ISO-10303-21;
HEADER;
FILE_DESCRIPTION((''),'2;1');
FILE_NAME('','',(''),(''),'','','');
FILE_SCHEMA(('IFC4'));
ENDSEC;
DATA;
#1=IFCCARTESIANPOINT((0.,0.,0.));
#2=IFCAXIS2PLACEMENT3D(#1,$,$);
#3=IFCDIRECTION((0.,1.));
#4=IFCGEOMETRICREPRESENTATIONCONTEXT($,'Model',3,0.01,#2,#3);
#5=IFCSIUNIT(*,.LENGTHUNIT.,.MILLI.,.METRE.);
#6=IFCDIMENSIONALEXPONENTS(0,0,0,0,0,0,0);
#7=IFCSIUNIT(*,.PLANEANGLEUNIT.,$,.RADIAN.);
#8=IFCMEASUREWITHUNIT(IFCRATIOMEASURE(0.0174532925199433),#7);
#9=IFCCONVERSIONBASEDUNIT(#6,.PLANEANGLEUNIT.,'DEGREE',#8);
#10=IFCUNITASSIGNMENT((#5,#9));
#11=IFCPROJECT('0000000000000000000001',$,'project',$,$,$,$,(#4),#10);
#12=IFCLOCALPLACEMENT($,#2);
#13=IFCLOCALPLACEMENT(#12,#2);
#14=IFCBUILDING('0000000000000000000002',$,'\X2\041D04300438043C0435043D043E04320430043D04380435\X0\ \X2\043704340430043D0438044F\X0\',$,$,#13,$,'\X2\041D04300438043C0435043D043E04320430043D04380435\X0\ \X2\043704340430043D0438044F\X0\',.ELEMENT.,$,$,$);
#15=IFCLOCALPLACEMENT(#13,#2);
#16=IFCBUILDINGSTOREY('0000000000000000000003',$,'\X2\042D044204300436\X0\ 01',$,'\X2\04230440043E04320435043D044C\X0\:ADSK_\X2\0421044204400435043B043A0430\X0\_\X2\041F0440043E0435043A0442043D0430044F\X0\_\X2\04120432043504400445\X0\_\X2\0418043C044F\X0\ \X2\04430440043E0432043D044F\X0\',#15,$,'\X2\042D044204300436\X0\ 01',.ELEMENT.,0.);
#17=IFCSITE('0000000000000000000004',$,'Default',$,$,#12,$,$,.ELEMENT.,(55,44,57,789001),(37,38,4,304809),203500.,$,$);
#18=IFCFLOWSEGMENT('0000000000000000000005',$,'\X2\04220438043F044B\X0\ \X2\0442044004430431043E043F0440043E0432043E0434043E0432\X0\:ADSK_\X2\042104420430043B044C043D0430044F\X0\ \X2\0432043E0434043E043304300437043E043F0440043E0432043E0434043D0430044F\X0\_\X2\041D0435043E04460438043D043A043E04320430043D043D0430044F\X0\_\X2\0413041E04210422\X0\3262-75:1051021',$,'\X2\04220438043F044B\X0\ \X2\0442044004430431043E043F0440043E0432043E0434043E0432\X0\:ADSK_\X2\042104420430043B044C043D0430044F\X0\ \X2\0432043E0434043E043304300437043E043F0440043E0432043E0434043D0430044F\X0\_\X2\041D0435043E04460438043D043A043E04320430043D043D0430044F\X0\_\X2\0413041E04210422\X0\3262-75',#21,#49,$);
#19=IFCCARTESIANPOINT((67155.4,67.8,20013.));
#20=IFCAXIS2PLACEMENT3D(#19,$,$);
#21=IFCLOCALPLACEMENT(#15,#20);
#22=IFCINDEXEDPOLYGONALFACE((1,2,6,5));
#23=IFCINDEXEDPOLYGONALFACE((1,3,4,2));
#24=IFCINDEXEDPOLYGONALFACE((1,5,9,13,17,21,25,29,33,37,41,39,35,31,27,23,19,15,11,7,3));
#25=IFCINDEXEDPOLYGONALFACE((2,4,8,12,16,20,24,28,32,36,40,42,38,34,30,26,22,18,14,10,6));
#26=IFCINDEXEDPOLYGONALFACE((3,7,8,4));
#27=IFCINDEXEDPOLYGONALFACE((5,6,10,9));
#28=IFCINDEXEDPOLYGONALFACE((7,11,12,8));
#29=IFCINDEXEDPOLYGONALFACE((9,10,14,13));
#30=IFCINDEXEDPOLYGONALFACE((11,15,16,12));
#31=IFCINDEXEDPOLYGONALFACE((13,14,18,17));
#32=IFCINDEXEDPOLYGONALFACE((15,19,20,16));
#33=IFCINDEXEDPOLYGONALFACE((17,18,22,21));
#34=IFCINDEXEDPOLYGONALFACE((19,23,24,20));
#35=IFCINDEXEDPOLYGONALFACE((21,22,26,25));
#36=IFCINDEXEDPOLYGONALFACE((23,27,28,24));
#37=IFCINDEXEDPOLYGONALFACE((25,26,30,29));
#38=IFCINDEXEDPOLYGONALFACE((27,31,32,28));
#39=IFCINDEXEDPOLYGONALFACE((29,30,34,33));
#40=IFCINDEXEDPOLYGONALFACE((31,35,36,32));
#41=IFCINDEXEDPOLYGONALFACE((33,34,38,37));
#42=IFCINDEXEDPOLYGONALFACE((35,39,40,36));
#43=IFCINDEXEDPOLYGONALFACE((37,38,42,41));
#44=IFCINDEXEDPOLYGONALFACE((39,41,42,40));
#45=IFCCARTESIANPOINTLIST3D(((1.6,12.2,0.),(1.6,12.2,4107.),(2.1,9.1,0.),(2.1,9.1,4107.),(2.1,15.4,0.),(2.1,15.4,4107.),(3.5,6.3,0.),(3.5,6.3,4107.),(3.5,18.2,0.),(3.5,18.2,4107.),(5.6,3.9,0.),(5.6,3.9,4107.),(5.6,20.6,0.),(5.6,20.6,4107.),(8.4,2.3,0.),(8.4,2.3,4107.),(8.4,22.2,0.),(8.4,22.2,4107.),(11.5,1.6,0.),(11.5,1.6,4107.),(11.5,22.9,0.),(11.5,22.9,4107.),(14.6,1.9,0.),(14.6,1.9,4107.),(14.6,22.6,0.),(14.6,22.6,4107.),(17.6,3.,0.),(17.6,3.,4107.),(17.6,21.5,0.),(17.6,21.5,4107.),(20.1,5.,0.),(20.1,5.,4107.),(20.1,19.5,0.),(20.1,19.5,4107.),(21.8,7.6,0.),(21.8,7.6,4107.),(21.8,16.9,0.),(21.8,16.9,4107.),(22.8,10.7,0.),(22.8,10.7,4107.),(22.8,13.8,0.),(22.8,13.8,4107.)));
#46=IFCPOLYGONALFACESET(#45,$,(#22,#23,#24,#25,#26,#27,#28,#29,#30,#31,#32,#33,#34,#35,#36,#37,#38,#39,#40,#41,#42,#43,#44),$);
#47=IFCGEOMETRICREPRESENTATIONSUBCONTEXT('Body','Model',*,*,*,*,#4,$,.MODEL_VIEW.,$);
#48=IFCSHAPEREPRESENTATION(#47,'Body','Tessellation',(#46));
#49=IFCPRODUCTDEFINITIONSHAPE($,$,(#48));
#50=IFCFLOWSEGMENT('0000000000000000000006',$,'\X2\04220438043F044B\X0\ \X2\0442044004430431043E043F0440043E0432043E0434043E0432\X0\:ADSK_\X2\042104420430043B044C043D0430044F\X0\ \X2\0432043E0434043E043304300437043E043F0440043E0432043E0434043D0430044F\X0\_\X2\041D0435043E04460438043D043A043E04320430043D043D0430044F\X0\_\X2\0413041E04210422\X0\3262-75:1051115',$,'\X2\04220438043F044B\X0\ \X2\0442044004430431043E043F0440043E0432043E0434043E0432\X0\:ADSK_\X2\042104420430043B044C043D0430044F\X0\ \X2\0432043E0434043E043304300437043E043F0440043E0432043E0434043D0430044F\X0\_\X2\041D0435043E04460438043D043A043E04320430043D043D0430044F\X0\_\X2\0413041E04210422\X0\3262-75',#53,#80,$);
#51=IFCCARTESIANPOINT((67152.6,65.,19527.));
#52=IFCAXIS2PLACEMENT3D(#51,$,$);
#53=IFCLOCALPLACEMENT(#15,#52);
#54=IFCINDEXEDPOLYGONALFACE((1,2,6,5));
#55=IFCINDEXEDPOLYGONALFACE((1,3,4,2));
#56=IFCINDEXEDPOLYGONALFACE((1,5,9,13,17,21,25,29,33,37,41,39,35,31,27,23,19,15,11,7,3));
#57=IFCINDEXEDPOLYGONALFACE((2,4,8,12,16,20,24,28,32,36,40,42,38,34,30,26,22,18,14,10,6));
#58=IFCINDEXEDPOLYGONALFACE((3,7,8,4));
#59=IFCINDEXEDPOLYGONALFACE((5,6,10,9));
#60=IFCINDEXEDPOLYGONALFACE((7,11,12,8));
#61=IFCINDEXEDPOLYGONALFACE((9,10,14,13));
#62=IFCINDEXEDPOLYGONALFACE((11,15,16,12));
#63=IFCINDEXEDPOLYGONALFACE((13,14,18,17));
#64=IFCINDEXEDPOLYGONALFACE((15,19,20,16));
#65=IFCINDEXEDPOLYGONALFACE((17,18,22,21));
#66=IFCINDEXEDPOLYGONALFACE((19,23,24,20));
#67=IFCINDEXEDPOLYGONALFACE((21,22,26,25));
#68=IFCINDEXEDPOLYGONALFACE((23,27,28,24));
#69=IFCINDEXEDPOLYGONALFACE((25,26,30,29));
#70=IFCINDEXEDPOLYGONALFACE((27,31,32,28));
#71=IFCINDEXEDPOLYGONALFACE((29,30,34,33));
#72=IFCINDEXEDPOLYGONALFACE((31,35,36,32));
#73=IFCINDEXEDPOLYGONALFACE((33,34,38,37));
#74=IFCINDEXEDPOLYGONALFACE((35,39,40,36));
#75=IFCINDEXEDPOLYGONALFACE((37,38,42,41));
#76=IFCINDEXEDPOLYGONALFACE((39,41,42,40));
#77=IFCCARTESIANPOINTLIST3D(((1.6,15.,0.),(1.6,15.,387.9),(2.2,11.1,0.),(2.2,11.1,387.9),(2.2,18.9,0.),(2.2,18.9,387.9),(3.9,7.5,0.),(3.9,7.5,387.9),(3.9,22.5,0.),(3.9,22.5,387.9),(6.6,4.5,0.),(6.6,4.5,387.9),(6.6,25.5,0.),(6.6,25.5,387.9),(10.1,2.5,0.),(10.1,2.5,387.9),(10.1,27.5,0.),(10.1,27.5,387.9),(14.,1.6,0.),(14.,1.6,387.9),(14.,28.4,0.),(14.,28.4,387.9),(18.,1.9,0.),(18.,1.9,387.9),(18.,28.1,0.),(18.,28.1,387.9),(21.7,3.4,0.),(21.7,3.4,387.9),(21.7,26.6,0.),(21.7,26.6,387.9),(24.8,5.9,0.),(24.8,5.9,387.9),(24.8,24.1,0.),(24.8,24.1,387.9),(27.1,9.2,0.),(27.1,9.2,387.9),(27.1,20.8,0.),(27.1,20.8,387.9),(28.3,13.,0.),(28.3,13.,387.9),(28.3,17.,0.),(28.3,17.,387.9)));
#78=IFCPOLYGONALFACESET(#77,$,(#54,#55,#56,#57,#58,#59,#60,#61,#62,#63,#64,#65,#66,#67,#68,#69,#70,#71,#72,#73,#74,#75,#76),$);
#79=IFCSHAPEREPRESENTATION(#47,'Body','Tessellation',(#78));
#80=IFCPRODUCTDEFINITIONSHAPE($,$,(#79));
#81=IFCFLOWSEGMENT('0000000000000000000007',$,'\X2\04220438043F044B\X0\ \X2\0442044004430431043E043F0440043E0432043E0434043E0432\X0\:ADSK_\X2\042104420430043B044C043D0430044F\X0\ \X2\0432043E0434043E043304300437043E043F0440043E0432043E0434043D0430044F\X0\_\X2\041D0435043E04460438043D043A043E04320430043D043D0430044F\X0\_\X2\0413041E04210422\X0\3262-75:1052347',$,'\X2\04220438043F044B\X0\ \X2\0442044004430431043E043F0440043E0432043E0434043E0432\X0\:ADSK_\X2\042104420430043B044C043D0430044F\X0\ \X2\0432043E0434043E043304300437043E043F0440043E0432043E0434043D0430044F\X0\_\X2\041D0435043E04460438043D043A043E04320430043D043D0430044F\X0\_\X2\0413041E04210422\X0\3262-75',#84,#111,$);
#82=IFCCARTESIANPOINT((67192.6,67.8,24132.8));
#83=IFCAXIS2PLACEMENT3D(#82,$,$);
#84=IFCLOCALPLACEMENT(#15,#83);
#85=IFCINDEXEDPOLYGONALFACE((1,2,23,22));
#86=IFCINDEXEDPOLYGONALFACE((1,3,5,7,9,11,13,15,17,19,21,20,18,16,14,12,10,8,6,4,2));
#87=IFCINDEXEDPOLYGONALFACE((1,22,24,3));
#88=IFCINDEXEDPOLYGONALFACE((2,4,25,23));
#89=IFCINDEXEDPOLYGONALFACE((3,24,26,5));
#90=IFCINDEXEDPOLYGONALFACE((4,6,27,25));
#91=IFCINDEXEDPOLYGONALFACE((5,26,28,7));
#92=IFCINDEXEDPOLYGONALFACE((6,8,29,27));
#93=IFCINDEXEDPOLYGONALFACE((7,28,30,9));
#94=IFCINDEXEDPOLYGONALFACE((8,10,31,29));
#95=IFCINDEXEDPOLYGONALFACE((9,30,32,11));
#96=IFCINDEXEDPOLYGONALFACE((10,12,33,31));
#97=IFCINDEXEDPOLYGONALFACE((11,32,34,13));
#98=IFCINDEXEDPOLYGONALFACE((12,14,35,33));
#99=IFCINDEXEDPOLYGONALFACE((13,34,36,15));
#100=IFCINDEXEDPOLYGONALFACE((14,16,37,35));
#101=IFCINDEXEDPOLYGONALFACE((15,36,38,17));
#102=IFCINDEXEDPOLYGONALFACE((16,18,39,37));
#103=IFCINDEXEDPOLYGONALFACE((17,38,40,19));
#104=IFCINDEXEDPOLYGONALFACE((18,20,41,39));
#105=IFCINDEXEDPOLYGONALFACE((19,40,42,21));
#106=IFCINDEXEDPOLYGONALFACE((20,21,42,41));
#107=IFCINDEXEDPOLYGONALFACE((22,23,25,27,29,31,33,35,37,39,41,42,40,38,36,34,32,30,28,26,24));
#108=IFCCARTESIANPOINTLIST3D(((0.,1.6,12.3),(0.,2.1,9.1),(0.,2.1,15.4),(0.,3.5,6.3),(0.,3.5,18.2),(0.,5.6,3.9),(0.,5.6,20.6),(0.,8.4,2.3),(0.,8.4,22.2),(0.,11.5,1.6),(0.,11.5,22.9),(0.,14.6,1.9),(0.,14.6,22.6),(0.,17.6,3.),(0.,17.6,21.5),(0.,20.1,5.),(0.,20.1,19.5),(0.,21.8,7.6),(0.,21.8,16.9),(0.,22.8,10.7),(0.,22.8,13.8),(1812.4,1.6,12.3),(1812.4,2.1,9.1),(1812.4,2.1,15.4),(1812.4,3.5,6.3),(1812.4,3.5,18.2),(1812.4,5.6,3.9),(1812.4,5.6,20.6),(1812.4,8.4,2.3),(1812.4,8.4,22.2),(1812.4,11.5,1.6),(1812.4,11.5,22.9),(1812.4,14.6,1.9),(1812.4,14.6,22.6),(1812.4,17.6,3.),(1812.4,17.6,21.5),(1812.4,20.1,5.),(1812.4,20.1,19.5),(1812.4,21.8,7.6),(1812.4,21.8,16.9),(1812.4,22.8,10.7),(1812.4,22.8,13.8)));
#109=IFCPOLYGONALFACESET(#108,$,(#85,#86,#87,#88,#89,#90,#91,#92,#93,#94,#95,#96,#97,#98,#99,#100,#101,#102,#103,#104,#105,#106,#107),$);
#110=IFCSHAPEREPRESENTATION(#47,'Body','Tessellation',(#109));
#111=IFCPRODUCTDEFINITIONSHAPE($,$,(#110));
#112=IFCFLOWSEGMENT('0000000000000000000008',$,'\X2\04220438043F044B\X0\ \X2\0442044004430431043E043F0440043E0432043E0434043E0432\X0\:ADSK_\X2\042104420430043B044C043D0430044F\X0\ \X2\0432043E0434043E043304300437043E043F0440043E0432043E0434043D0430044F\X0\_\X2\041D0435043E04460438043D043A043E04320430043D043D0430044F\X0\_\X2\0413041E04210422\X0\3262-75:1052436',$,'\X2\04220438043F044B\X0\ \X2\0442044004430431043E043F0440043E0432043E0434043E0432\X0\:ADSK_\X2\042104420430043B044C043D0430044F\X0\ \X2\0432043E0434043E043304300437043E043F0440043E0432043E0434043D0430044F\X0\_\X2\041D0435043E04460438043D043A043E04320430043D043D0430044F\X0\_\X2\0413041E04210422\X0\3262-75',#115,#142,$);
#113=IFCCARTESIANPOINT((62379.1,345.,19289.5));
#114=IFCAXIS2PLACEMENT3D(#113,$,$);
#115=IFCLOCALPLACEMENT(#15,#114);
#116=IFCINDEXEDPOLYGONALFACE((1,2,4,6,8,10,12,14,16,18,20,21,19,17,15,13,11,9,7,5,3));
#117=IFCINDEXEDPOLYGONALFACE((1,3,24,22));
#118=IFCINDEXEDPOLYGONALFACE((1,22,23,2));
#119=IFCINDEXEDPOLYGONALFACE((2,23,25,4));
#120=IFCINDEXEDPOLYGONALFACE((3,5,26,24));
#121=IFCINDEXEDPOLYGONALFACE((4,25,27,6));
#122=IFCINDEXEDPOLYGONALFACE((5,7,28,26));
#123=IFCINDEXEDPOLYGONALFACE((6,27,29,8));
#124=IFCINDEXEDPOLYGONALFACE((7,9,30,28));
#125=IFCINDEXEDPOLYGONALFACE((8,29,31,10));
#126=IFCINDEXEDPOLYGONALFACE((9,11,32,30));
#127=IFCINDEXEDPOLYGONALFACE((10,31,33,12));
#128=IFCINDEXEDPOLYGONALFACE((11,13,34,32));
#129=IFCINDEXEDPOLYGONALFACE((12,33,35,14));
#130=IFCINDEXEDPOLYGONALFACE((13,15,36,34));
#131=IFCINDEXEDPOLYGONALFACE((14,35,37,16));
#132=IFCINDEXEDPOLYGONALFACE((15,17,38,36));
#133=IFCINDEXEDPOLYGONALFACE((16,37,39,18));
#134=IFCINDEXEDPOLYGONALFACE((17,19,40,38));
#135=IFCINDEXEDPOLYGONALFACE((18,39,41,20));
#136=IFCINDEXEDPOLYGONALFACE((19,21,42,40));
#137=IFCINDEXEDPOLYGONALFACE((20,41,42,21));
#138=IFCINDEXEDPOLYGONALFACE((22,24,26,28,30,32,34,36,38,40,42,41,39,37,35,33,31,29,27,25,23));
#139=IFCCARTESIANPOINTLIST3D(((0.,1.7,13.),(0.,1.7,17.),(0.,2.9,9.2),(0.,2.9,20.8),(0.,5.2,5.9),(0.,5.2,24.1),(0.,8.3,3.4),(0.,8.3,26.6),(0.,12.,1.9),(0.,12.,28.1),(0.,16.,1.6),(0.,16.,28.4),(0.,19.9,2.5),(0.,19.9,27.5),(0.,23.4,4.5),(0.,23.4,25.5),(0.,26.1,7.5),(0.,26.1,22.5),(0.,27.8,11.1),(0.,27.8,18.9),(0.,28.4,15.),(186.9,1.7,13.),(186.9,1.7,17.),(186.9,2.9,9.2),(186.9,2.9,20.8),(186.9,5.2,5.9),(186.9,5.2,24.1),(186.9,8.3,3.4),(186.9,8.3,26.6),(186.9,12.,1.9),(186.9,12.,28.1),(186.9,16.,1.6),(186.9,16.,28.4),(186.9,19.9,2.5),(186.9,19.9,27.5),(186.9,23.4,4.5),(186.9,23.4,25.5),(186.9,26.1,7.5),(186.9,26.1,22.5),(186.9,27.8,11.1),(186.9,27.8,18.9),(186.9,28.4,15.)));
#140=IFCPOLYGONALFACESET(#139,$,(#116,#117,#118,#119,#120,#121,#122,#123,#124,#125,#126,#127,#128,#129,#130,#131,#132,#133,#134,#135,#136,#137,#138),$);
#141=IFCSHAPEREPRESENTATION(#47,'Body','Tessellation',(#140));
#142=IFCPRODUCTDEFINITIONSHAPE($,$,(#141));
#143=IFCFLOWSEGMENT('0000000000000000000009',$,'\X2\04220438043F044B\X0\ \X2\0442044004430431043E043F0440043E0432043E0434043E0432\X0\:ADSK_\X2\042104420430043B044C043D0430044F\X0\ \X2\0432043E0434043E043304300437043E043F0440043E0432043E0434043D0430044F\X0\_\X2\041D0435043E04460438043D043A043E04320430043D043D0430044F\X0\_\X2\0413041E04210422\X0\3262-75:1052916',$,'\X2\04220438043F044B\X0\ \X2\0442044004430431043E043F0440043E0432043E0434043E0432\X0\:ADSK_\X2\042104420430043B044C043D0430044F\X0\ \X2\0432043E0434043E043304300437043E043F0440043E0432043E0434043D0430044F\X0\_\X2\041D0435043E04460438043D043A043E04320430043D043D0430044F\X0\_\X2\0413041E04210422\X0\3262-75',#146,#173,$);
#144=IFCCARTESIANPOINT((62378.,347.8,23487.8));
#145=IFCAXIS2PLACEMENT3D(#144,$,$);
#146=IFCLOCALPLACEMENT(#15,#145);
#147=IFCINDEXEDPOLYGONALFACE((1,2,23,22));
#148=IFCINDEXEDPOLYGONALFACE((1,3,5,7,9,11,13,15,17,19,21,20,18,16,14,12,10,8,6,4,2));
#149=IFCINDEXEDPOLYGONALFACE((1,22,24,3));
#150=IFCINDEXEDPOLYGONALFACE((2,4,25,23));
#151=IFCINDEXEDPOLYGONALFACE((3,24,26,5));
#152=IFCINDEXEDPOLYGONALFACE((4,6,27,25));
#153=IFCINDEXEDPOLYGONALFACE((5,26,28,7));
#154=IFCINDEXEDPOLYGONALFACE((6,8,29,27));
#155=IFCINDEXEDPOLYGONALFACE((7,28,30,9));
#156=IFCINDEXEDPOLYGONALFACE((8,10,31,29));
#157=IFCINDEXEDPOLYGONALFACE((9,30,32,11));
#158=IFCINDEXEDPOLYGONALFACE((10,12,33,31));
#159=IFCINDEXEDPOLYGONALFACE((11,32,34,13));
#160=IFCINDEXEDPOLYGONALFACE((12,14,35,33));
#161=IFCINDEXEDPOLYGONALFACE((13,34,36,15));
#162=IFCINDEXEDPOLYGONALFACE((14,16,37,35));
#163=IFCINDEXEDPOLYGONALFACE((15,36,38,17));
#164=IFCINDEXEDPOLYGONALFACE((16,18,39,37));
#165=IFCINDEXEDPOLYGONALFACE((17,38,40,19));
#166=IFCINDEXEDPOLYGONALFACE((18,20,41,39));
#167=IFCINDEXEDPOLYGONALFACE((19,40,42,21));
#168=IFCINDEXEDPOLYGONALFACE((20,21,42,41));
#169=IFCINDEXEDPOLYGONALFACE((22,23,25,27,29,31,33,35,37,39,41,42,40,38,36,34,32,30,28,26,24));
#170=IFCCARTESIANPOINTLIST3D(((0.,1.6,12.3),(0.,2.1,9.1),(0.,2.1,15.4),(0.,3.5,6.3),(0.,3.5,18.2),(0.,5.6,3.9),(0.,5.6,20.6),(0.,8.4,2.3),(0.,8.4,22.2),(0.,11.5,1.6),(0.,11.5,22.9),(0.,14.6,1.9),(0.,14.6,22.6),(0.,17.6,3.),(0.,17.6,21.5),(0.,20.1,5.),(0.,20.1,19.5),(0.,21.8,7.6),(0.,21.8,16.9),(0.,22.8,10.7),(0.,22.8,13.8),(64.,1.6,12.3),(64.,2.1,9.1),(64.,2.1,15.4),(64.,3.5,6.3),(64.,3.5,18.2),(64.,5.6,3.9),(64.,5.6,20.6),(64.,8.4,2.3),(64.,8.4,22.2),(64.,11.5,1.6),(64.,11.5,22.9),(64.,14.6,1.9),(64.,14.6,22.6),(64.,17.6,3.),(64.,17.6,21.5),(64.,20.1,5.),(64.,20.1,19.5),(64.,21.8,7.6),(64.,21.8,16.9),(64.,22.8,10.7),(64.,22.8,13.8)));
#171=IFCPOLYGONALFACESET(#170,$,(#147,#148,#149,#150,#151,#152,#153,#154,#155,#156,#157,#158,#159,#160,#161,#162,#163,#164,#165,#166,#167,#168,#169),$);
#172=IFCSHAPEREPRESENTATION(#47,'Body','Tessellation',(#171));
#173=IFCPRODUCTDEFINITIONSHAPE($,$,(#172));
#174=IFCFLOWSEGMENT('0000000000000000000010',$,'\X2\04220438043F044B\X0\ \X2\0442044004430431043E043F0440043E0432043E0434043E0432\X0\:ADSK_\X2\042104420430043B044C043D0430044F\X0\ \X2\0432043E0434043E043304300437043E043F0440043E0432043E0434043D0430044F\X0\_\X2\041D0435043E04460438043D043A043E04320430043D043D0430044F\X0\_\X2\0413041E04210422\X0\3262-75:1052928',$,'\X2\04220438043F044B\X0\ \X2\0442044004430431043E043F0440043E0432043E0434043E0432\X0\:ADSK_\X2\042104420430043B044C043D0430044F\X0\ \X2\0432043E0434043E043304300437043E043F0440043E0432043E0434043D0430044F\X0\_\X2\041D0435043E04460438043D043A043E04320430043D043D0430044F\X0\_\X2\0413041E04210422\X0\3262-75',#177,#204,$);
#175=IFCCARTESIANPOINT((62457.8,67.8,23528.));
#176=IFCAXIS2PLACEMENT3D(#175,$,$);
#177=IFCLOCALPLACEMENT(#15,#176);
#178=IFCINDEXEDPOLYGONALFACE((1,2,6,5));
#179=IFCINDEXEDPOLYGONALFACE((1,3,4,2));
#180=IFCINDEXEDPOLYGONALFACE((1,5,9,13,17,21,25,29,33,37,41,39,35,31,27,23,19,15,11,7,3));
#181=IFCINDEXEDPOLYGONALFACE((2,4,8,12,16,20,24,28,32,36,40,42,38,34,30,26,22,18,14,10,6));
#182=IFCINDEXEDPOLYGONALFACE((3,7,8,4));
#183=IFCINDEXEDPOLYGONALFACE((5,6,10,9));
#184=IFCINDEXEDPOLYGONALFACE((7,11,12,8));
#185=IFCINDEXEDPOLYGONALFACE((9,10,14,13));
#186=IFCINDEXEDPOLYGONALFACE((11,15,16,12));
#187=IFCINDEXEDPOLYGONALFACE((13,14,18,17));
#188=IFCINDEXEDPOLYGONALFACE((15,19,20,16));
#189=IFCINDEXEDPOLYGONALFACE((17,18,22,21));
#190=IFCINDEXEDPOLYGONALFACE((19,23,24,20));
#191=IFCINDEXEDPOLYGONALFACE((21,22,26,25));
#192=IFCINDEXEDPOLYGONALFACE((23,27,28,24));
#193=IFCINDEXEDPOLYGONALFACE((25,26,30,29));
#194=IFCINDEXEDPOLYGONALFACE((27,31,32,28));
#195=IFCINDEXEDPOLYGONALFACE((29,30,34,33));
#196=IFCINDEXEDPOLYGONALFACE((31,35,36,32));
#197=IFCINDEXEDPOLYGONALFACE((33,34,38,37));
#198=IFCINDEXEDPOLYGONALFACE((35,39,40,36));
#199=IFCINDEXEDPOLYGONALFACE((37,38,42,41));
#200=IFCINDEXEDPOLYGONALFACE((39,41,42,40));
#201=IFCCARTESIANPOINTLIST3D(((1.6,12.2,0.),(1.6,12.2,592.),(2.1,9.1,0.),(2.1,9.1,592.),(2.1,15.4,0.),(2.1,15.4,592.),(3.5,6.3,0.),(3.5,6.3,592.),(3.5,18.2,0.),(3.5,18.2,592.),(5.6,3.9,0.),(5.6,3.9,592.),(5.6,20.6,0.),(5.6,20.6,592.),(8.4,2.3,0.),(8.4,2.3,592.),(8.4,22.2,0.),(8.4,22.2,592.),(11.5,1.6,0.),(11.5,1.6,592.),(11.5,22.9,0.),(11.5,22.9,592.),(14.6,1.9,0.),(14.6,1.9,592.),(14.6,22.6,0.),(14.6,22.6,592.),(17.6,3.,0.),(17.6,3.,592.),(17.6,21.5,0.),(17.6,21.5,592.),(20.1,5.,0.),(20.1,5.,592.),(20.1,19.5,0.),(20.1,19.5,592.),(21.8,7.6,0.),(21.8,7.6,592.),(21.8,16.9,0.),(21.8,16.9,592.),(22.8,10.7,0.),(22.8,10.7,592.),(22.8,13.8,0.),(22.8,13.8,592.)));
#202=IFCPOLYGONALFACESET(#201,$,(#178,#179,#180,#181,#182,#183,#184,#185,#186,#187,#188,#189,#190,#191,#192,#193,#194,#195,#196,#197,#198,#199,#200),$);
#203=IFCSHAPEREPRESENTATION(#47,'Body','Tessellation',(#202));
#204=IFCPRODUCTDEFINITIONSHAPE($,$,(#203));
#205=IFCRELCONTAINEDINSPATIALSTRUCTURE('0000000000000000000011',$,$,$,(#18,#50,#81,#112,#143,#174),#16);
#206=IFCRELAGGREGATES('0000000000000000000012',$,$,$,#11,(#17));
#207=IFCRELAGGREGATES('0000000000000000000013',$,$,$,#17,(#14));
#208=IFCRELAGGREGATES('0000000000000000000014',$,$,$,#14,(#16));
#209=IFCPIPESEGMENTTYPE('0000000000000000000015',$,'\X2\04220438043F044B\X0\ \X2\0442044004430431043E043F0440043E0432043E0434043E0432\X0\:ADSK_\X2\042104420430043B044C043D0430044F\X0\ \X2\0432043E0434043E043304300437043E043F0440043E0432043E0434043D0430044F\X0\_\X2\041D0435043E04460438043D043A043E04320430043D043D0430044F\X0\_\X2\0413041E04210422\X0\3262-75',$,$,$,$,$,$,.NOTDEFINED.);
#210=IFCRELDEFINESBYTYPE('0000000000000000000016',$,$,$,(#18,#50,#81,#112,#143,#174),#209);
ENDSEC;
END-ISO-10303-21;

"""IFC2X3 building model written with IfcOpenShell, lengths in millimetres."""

from ifc_helpers import new_model, entity, si_unit, converted_unit, direction, frame, origin, origin_2d_with_axis, place, context, subcontext, project, spatial, circle, extrude, type_object, element, save


model = new_model("IFC2X3")

# Units and contexts
model_context = context("Model", 3, precision=0.01, world=origin(), true_north=direction((0.0, 1.0)))
body_context = subcontext(model_context, "Body", "Model", "MODEL_VIEW")
ifc_project = project(units=[si_unit("LENGTHUNIT", "METRE", prefix="MILLI"), converted_unit("PLANEANGLEUNIT", "DEGREE", entity("IfcRatioMeasure", 0.0174532925199433), si_unit("PLANEANGLEUNIT", "RADIAN"), dimensions=[0, 0, 0, 0, 0, 0, 0])], contexts=[model_context])

# Site, building, storey
site_placement = place(None, origin())
site = spatial("IfcSite", under=ifc_project, at=site_placement, Name="Default", CompositionType="ELEMENT", RefLatitude=(55, 44, 57, 789001), RefLongitude=(37, 38, 4, 304809), RefElevation=203500.0)
building_placement = place(site_placement, origin())
building = spatial("IfcBuilding", under=site, at=building_placement, Name="Наименование здания", LongName="Наименование здания", CompositionType="ELEMENT")
storey_placement = place(building_placement, origin())
storey = spatial("IfcBuildingStorey", under=building, at=storey_placement, Name="Этаж 01", ObjectType="Уровень:ADSK_Стрелка_Проектная_Вверх_Имя уровня", LongName="Этаж 01", CompositionType="ELEMENT", Elevation=0.0)

# Flow segments
pipe_segment_type = type_object("IfcPipeSegmentType", Name="Типы трубопроводов:ADSK_Стальная водогазопроводная_Неоцинкованная_ГОСТ3262-75", PredefinedType="NOTDEFINED")
flow_segment_1_placement = place(storey_placement, frame((67155.4, 67.8, 20013.0)))
element("IfcFlowSegment", 1, at=flow_segment_1_placement, inside=storey, type_object=pipe_segment_type, Name="Типы трубопроводов:ADSK_Стальная водогазопроводная_Неоцинкованная_ГОСТ3262-75:1051021", ObjectType="Типы трубопроводов:ADSK_Стальная водогазопроводная_Неоцинкованная_ГОСТ3262-75", context=body_context, shape_type="SweptSolid", body=[
    extrude(circle(Radius=10.7, at=origin_2d_with_axis()), frame((12.2, 12.2, 0.0), z_axis=(0.0, 0.0, 1.0), x_axis=(-1.0, 0.0, 0.0)), (0.0, 0.0, 1.0), 4107.0),
])
flow_segment_2_placement = place(storey_placement, frame((67152.6, 65.0, 19527.0)))
element("IfcFlowSegment", 2, at=flow_segment_2_placement, inside=storey, type_object=pipe_segment_type, Name="Типы трубопроводов:ADSK_Стальная водогазопроводная_Неоцинкованная_ГОСТ3262-75:1051115", ObjectType="Типы трубопроводов:ADSK_Стальная водогазопроводная_Неоцинкованная_ГОСТ3262-75", context=body_context, shape_type="SweptSolid", body=[
    extrude(circle(Radius=13.4, at=origin_2d_with_axis()), frame((15.0, 15.0, 0.0), z_axis=(0.0, 0.0, 1.0), x_axis=(-1.0, 0.0, 0.0)), (0.0, 0.0, 1.0), 387.9),
])
flow_segment_3_placement = place(storey_placement, frame((67192.6, 67.8, 24132.8)))
element("IfcFlowSegment", 3, at=flow_segment_3_placement, inside=storey, type_object=pipe_segment_type, Name="Типы трубопроводов:ADSK_Стальная водогазопроводная_Неоцинкованная_ГОСТ3262-75:1052347", ObjectType="Типы трубопроводов:ADSK_Стальная водогазопроводная_Неоцинкованная_ГОСТ3262-75", context=body_context, shape_type="SweptSolid", body=[
    extrude(circle(Radius=10.7, at=origin_2d_with_axis()), frame((0.0, 12.2, 12.2), z_axis=(1.0, 0.0, 0.0), x_axis=(0.0, -1.0, 0.0)), (0.0, 0.0, 1.0), 1812.4),
])
flow_segment_4_placement = place(storey_placement, frame((62379.1, 345.0, 19289.5)))
element("IfcFlowSegment", 4, at=flow_segment_4_placement, inside=storey, type_object=pipe_segment_type, Name="Типы трубопроводов:ADSK_Стальная водогазопроводная_Неоцинкованная_ГОСТ3262-75:1052436", ObjectType="Типы трубопроводов:ADSK_Стальная водогазопроводная_Неоцинкованная_ГОСТ3262-75", context=body_context, shape_type="SweptSolid", body=[
    extrude(circle(Radius=13.4, at=origin_2d_with_axis()), frame((0.0, 15.0, 15.0), z_axis=(1.0, 0.0, 0.0), x_axis=(0.0, 1.0, 0.0)), (0.0, 0.0, 1.0), 186.9),
])
flow_segment_5_placement = place(storey_placement, frame((62378.0, 347.8, 23487.8)))
element("IfcFlowSegment", 5, at=flow_segment_5_placement, inside=storey, type_object=pipe_segment_type, Name="Типы трубопроводов:ADSK_Стальная водогазопроводная_Неоцинкованная_ГОСТ3262-75:1052916", ObjectType="Типы трубопроводов:ADSK_Стальная водогазопроводная_Неоцинкованная_ГОСТ3262-75", context=body_context, shape_type="SweptSolid", body=[
    extrude(circle(Radius=10.7, at=origin_2d_with_axis()), frame((0.0, 12.2, 12.2), z_axis=(1.0, 0.0, 0.0), x_axis=(0.0, -1.0, 0.0)), (0.0, 0.0, 1.0), 64.0),
])
flow_segment_6_placement = place(storey_placement, frame((62457.8, 67.8, 23528.0)))
element("IfcFlowSegment", 6, at=flow_segment_6_placement, inside=storey, type_object=pipe_segment_type, Name="Типы трубопроводов:ADSK_Стальная водогазопроводная_Неоцинкованная_ГОСТ3262-75:1052928", ObjectType="Типы трубопроводов:ADSK_Стальная водогазопроводная_Неоцинкованная_ГОСТ3262-75", context=body_context, shape_type="SweptSolid", body=[
    extrude(circle(Radius=10.7, at=origin_2d_with_axis()), frame((12.2, 12.2, 0.0), z_axis=(0.0, 0.0, 1.0), x_axis=(-1.0, 0.0, 0.0)), (0.0, 0.0, 1.0), 592.0),
])

save(model, "model.ifc")
